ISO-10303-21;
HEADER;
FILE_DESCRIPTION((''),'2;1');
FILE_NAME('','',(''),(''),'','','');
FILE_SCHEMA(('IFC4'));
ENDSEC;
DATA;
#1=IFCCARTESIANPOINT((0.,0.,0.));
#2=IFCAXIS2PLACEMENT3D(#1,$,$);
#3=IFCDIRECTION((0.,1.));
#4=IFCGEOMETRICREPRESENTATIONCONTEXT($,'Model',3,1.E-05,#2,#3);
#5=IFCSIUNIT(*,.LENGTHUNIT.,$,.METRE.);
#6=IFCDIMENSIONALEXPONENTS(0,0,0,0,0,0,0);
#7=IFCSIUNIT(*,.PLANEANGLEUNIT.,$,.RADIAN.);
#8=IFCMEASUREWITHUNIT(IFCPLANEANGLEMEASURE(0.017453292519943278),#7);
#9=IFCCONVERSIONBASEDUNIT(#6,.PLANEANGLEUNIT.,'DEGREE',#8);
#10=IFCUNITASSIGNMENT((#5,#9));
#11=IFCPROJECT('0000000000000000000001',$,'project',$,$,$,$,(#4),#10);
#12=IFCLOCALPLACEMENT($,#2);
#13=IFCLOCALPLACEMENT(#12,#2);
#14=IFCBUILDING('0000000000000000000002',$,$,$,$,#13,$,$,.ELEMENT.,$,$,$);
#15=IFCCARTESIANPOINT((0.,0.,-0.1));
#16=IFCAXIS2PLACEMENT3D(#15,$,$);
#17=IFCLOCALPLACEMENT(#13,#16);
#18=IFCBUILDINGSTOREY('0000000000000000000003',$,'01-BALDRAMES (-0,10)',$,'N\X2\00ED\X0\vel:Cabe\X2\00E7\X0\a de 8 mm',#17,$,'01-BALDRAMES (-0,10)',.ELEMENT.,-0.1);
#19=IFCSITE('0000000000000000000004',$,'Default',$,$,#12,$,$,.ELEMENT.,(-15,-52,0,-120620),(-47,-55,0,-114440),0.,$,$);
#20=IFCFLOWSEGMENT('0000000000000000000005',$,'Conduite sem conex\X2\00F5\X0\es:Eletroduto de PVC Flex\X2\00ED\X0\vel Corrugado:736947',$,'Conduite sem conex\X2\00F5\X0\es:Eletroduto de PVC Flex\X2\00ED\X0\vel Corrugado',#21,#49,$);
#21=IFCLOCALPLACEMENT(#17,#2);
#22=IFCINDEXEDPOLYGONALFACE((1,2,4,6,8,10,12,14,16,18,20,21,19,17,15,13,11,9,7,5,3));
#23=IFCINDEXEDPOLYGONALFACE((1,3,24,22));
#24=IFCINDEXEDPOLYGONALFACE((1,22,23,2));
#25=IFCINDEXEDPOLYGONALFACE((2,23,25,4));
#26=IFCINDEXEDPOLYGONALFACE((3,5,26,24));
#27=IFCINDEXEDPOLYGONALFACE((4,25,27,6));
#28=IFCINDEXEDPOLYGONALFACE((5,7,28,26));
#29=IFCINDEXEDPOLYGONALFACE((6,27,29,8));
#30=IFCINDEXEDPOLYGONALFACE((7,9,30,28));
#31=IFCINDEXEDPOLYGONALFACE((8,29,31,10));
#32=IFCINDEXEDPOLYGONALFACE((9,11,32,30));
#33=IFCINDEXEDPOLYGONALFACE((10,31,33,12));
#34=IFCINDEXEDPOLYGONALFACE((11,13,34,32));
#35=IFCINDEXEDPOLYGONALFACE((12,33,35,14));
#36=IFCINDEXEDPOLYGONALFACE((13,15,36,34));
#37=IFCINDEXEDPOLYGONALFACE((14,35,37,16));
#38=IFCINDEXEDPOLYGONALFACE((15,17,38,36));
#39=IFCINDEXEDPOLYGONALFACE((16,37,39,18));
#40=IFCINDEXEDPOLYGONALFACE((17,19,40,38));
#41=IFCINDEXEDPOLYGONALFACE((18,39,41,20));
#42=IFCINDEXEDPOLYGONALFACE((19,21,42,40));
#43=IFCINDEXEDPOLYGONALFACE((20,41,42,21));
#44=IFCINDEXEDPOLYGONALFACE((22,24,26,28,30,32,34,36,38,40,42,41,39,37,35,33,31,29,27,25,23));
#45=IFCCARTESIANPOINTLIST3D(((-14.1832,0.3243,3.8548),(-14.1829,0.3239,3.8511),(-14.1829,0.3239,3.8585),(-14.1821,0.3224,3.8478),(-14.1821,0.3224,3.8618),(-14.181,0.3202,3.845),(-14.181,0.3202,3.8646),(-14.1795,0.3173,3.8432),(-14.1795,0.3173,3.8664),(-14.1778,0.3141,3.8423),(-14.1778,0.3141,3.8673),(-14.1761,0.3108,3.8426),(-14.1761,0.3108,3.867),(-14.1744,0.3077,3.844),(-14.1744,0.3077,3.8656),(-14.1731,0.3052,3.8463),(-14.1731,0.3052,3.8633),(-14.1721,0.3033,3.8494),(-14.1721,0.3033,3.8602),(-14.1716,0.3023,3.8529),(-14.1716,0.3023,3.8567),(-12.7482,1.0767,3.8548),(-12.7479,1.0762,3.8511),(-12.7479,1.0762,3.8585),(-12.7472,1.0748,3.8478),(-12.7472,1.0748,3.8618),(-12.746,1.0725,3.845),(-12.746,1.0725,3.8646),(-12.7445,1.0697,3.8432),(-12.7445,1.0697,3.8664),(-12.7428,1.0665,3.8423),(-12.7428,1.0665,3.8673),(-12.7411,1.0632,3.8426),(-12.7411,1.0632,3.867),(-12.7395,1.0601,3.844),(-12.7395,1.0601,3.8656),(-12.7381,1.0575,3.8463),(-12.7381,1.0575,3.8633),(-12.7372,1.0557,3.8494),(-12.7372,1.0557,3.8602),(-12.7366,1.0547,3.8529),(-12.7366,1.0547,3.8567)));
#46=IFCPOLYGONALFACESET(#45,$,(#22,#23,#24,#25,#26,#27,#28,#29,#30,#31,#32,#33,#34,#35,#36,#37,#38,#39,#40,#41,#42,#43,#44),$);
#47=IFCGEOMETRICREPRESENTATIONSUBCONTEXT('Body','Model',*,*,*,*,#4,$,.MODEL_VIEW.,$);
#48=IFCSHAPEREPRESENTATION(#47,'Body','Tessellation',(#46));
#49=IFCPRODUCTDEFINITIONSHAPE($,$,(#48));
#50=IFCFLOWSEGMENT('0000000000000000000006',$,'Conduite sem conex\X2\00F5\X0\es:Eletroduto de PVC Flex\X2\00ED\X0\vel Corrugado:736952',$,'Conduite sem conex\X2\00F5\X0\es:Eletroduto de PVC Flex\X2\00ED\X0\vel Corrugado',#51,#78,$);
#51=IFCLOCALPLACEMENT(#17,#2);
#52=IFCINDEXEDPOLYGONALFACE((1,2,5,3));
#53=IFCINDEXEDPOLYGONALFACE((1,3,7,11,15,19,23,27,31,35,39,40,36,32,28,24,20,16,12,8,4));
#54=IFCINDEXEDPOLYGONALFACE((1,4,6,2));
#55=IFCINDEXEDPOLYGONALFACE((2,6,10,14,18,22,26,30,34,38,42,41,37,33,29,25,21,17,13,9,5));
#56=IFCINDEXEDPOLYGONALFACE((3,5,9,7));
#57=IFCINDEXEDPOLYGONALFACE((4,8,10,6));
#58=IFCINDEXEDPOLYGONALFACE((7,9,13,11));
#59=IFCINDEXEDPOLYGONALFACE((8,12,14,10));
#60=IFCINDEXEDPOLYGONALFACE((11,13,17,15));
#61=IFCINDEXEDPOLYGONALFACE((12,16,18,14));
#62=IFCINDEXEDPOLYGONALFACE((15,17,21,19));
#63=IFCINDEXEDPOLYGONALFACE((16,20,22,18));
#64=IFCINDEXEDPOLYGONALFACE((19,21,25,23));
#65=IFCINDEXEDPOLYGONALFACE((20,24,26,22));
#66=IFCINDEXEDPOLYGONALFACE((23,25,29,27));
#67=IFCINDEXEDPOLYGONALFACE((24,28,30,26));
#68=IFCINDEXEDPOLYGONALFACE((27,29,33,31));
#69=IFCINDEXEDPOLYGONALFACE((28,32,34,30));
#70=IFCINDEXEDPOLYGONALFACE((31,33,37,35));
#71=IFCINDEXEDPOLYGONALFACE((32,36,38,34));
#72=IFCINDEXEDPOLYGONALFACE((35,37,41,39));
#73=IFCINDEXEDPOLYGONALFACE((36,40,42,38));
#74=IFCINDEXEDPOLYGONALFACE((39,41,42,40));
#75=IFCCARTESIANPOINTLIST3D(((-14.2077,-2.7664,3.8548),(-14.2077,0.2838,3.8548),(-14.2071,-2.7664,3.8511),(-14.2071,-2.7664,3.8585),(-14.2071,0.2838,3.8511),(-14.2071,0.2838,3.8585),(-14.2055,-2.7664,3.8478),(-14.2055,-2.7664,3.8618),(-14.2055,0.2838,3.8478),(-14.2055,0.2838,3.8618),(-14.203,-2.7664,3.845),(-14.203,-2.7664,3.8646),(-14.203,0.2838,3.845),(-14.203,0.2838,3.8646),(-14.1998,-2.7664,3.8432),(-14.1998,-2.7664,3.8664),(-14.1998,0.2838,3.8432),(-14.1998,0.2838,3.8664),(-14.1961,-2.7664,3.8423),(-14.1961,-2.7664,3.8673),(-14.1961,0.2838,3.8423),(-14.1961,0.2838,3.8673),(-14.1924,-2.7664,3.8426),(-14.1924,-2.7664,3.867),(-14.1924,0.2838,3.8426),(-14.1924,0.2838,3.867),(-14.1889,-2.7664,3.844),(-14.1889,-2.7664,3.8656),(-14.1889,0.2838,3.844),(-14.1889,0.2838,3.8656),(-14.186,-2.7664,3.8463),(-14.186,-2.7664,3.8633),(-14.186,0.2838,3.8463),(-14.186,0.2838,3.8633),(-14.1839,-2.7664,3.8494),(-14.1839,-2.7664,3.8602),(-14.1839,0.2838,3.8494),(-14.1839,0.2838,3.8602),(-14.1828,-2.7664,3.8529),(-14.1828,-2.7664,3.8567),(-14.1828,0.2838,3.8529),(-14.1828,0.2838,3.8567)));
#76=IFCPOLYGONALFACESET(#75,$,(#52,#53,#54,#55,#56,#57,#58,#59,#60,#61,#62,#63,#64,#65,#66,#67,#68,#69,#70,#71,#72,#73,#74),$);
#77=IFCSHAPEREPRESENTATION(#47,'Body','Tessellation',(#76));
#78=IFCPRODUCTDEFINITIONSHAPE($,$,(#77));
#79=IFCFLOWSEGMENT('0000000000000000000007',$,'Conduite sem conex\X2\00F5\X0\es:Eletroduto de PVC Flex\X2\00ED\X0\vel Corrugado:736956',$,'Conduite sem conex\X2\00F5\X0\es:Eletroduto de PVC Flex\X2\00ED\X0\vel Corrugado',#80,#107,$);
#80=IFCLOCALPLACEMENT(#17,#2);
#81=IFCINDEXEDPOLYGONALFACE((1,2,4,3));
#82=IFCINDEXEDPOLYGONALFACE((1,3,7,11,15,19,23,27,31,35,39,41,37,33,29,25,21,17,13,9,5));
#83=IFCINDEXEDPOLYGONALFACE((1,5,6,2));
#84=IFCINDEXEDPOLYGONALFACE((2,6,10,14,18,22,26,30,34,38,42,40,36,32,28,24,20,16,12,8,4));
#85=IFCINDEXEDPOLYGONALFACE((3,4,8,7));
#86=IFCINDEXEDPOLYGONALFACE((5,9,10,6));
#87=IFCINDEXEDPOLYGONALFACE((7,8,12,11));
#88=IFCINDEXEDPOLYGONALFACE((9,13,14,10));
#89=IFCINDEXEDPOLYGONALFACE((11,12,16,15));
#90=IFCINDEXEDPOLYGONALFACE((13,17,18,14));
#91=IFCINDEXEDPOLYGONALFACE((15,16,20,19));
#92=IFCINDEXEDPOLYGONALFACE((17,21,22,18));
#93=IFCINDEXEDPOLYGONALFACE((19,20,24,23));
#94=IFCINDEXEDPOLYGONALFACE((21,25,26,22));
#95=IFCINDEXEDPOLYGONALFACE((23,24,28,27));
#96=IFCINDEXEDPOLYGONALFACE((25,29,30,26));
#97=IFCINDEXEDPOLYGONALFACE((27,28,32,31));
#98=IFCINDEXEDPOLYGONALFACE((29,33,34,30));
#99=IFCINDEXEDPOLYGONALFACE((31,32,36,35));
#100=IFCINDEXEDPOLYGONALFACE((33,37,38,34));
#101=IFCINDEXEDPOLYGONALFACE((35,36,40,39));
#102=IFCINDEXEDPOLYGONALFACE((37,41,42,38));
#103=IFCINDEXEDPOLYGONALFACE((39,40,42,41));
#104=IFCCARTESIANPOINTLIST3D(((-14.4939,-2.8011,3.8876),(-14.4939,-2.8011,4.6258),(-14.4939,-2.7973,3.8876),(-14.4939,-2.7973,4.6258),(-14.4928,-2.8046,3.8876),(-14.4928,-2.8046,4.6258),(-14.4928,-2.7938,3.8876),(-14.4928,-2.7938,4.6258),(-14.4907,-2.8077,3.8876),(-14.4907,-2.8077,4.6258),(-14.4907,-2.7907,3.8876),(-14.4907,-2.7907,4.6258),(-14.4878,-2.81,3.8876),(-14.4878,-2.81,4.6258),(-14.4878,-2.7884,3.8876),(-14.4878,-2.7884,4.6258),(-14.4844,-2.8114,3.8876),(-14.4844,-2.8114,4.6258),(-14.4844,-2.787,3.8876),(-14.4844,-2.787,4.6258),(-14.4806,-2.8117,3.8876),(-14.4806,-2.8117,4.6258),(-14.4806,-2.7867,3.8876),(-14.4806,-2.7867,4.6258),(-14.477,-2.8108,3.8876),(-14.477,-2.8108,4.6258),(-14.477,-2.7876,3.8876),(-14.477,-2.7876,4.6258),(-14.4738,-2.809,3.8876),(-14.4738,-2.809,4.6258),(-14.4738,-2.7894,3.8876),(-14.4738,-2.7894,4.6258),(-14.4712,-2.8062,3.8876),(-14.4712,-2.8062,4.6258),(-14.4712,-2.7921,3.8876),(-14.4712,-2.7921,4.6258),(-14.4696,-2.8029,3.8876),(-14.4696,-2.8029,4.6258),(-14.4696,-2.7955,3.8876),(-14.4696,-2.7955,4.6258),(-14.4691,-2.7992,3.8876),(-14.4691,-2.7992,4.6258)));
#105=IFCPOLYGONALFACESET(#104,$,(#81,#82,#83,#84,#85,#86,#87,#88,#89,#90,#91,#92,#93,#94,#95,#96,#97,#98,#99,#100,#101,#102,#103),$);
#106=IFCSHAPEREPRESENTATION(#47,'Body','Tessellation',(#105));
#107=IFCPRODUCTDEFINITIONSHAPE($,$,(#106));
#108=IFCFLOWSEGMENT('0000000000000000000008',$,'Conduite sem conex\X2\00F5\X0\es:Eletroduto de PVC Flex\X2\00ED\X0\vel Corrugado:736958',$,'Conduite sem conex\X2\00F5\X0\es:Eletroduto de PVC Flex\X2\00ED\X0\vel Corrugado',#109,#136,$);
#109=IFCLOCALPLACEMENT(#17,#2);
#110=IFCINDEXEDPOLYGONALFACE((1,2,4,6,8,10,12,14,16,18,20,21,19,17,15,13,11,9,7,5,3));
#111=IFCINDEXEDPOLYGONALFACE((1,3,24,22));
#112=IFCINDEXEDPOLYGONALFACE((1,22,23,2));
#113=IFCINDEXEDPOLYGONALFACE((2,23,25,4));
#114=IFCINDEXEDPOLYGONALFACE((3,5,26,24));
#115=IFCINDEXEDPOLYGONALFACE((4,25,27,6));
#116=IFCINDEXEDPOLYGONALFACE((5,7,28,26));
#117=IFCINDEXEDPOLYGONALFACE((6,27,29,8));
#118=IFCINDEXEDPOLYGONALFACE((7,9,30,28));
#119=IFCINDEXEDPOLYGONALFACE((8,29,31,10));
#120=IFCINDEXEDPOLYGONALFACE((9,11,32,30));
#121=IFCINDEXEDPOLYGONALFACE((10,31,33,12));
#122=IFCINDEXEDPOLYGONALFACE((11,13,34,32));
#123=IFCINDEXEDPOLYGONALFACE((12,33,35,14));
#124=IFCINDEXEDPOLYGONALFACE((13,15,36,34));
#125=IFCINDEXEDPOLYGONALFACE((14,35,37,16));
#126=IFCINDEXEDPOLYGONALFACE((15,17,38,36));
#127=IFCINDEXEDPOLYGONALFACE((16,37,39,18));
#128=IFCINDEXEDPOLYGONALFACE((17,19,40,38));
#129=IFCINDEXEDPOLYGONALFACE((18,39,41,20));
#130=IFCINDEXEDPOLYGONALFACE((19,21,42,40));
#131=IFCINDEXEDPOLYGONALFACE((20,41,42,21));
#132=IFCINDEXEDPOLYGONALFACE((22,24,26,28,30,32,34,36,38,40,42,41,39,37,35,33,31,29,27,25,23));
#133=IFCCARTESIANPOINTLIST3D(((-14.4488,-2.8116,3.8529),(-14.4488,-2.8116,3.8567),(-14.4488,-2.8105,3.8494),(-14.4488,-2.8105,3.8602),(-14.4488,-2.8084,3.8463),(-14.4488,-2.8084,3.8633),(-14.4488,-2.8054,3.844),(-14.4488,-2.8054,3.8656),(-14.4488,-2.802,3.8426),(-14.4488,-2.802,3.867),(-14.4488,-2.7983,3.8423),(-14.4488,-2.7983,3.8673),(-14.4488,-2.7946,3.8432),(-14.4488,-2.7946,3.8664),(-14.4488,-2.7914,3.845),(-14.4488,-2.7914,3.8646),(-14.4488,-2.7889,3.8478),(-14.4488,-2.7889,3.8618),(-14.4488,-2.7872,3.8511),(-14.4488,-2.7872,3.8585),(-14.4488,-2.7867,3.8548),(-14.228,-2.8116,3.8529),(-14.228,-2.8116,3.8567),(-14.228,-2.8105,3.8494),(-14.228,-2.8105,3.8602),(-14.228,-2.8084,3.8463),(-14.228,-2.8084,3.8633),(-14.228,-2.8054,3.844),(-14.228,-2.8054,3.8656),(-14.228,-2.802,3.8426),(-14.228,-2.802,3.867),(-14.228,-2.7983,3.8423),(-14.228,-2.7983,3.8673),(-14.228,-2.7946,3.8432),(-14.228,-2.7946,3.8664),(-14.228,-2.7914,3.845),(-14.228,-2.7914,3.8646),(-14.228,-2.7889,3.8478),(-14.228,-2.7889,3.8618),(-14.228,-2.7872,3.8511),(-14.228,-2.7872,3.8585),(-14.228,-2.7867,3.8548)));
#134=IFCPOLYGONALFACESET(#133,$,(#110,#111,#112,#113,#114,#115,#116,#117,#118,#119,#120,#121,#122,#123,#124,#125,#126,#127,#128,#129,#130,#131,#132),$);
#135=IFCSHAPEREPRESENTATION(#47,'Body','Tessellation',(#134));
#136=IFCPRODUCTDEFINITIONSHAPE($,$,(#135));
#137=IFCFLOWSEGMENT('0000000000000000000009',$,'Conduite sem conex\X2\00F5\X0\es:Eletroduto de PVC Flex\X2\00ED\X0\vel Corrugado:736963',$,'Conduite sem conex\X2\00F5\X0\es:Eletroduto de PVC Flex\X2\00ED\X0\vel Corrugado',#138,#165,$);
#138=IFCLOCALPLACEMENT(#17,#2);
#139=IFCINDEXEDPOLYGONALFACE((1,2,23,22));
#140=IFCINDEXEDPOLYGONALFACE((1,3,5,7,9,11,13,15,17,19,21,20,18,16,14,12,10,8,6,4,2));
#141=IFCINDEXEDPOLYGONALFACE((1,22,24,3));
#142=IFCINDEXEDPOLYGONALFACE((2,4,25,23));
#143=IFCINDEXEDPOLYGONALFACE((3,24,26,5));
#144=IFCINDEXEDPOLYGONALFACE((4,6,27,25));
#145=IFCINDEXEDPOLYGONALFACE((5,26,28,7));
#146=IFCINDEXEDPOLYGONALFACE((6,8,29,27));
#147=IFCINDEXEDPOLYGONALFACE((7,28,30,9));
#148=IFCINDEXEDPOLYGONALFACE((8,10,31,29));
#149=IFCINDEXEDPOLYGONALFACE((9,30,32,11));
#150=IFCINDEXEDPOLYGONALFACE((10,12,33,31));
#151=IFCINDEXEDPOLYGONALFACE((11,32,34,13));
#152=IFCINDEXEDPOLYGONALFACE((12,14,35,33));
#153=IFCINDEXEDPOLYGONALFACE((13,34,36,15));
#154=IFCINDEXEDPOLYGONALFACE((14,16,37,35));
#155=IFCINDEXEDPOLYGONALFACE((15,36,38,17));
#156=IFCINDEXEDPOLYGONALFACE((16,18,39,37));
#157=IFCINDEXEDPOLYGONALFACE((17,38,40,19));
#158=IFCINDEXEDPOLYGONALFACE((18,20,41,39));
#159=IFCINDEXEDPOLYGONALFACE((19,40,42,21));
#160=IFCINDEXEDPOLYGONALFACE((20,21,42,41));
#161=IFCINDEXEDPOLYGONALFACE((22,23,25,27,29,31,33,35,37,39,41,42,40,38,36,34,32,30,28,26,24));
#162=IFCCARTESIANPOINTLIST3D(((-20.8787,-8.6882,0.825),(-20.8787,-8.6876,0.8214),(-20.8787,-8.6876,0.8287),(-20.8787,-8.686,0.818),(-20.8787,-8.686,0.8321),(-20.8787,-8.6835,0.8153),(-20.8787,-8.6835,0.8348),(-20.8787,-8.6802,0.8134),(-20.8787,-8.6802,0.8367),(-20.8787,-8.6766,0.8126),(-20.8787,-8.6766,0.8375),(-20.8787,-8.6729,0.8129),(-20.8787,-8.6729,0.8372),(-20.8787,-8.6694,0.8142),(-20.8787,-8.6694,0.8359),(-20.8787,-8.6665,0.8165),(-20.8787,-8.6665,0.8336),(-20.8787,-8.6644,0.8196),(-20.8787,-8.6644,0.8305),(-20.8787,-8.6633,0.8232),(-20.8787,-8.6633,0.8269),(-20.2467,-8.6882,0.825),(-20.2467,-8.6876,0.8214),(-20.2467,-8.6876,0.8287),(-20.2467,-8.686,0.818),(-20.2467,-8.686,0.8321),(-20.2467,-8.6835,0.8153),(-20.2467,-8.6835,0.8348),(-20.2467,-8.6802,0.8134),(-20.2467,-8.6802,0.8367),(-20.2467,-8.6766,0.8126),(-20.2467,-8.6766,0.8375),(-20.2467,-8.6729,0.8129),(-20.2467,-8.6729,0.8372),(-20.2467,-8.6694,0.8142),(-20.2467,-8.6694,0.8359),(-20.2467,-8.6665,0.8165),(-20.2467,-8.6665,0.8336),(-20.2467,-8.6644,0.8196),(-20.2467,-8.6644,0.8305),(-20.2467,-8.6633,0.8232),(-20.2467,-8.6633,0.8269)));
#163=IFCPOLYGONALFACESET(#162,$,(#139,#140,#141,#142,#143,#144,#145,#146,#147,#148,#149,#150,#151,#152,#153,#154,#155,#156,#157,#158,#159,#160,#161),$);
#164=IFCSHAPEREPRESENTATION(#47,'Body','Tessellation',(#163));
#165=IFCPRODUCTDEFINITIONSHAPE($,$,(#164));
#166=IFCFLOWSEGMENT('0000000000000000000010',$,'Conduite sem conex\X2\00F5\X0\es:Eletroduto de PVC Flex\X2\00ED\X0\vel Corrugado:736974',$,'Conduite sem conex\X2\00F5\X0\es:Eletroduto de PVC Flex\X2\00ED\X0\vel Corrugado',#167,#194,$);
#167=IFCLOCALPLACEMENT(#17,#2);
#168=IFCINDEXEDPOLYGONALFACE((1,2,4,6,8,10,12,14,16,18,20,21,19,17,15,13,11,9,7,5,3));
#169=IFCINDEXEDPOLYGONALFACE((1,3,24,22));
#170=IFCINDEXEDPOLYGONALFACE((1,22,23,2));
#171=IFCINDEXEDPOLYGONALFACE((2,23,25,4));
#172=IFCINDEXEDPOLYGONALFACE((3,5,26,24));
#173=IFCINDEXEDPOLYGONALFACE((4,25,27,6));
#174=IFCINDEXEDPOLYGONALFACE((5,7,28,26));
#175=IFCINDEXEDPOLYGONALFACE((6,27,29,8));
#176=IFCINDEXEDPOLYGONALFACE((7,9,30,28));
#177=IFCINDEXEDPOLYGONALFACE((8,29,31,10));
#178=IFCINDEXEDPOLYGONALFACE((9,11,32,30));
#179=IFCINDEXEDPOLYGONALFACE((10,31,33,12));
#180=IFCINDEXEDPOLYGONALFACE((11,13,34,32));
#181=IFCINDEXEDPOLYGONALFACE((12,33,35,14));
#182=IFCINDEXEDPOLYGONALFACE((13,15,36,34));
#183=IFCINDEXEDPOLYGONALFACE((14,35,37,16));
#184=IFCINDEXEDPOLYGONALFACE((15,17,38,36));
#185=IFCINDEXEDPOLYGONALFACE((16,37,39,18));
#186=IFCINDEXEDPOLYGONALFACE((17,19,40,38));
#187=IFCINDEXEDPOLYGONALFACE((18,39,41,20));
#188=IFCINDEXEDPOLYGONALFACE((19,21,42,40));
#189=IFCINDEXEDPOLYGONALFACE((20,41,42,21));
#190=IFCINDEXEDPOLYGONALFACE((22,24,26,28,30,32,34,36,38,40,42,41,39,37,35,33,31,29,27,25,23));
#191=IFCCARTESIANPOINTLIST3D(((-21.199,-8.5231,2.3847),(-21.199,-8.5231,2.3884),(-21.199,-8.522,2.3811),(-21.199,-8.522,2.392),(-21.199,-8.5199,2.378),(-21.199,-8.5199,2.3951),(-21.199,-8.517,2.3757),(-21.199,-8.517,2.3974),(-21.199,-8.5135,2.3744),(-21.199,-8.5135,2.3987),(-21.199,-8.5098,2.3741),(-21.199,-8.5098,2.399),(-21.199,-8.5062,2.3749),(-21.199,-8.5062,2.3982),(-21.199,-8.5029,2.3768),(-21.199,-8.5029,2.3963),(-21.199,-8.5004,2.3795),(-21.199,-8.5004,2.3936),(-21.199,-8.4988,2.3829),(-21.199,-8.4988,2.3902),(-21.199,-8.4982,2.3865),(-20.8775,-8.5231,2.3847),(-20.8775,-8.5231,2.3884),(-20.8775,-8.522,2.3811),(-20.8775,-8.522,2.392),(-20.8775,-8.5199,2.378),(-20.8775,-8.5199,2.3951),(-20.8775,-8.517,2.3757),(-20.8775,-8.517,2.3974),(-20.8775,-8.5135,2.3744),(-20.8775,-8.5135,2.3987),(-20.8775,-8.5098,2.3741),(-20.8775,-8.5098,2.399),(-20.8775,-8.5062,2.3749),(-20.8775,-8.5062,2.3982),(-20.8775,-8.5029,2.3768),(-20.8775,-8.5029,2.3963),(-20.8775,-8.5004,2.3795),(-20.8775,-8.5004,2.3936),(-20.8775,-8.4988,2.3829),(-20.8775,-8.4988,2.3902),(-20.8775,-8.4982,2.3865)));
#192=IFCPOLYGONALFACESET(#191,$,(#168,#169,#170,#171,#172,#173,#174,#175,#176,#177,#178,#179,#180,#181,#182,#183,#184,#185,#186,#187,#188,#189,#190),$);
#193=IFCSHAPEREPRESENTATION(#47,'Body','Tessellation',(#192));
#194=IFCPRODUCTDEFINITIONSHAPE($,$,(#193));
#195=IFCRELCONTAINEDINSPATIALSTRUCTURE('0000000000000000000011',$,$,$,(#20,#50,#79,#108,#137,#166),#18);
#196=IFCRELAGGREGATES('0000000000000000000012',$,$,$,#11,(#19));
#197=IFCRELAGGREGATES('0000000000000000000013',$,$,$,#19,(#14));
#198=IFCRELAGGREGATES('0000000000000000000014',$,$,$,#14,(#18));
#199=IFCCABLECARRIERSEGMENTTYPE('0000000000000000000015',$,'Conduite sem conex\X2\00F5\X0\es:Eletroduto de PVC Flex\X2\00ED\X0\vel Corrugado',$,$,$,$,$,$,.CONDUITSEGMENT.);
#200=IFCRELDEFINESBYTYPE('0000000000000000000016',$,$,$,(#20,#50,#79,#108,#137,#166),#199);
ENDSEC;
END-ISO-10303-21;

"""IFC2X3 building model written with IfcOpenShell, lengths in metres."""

from ifc_helpers import new_model, entity, si_unit, converted_unit, direction, frame, frame_2d, origin, place, context, subcontext, project, spatial, circle, extrude, type_object, element, save


model = new_model("IFC2X3")

# Units and contexts
model_context = context("Model", 3, precision=1e-05, world=origin(), true_north=direction((0.0, 1.0)))
body_context = subcontext(model_context, "Body", "Model", "MODEL_VIEW")
ifc_project = project(units=[si_unit("LENGTHUNIT", "METRE"), converted_unit("PLANEANGLEUNIT", "DEGREE", entity("IfcPlaneAngleMeasure", 0.017453292519943278), si_unit("PLANEANGLEUNIT", "RADIAN"), dimensions=[0, 0, 0, 0, 0, 0, 0])], contexts=[model_context])

# Site, building, storey
site_placement = place(None, origin())
site = spatial("IfcSite", under=ifc_project, at=site_placement, Name="Default", CompositionType="ELEMENT", RefLatitude=(-15, -52, 0, -120620), RefLongitude=(-47, -55, 0, -114440), RefElevation=0.0)
building_placement = place(site_placement, origin())
building = spatial("IfcBuilding", under=site, at=building_placement, CompositionType="ELEMENT")
storey_placement = place(building_placement, frame((0.0, 0.0, -0.1)))
storey = spatial("IfcBuildingStorey", under=building, at=storey_placement, Name="01-BALDRAMES (-0,10)", ObjectType="Nível:Cabeça de 8 mm", LongName="01-BALDRAMES (-0,10)", CompositionType="ELEMENT", Elevation=-0.1)

# Flow segments
cable_carrier_segment_type = type_object("IfcCableCarrierSegmentType", Name="Conduite sem conexões:Eletroduto de PVC Flexível Corrugado", PredefinedType="CONDUITSEGMENT")
flow_segment_1_placement = place(storey_placement, origin())
element("IfcFlowSegment", 1, at=flow_segment_1_placement, inside=storey, type_object=cable_carrier_segment_type, Name="Conduite sem conexões:Eletroduto de PVC Flexível Corrugado:736947", ObjectType="Conduite sem conexões:Eletroduto de PVC Flexível Corrugado", context=body_context, shape_type="SweptSolid", body=[
    extrude(circle(Radius=0.0125, at=frame_2d((0.0, 0.0), x_axis=(1.0, 0.0))), frame((-14.1773, 0.3133, 3.8548), z_axis=(0.885651, 0.464351, 0.0), x_axis=(-0.464351, 0.885651, 0.0)), (0.0, 0.0, 1.0), 1.6202),
])
flow_segment_2_placement = place(storey_placement, origin())
element("IfcFlowSegment", 2, at=flow_segment_2_placement, inside=storey, type_object=cable_carrier_segment_type, Name="Conduite sem conexões:Eletroduto de PVC Flexível Corrugado:736952", ObjectType="Conduite sem conexões:Eletroduto de PVC Flexível Corrugado", context=body_context, shape_type="SweptSolid", body=[
    extrude(circle(Radius=0.0125, at=frame_2d((0.0, 0.0), x_axis=(1.0, 0.0))), frame((-14.1952, -2.7664, 3.8548), z_axis=(0.0, 1.0, 0.0), x_axis=(-1.0, 0.0, 0.0)), (0.0, 0.0, 1.0), 3.0502),
])
flow_segment_3_placement = place(storey_placement, origin())
element("IfcFlowSegment", 3, at=flow_segment_3_placement, inside=storey, type_object=cable_carrier_segment_type, Name="Conduite sem conexões:Eletroduto de PVC Flexível Corrugado:736956", ObjectType="Conduite sem conexões:Eletroduto de PVC Flexível Corrugado", context=body_context, shape_type="SweptSolid", body=[
    extrude(circle(Radius=0.0125, at=frame_2d((0.0, 0.0), x_axis=(1.0, 0.0))), frame((-14.4816, -2.7992, 3.8876)), (0.0, 0.0, 1.0), 0.7382),
])
flow_segment_4_placement = place(storey_placement, origin())
element("IfcFlowSegment", 4, at=flow_segment_4_placement, inside=storey, type_object=cable_carrier_segment_type, Name="Conduite sem conexões:Eletroduto de PVC Flexível Corrugado:736958", ObjectType="Conduite sem conexões:Eletroduto de PVC Flexível Corrugado", context=body_context, shape_type="SweptSolid", body=[
    extrude(circle(Radius=0.0125, at=frame_2d((0.0, 0.0), x_axis=(1.0, 0.0))), frame((-14.4488, -2.7992, 3.8548), z_axis=(1.0, 0.0, 0.0), x_axis=(0.0, 1.0, 0.0)), (0.0, 0.0, 1.0), 0.2208),
])
flow_segment_5_placement = place(storey_placement, origin())
element("IfcFlowSegment", 5, at=flow_segment_5_placement, inside=storey, type_object=cable_carrier_segment_type, Name="Conduite sem conexões:Eletroduto de PVC Flexível Corrugado:736963", ObjectType="Conduite sem conexões:Eletroduto de PVC Flexível Corrugado", context=body_context, shape_type="SweptSolid", body=[
    extrude(circle(Radius=0.0125, at=frame_2d((0.0, 0.0), x_axis=(1.0, 0.0))), frame((-20.8787, -8.6757, 0.825), z_axis=(1.0, 0.0, 0.0), x_axis=(0.0, -1.0, 0.0)), (0.0, 0.0, 1.0), 0.632),
])
flow_segment_6_placement = place(storey_placement, origin())
element("IfcFlowSegment", 6, at=flow_segment_6_placement, inside=storey, type_object=cable_carrier_segment_type, Name="Conduite sem conexões:Eletroduto de PVC Flexível Corrugado:736974", ObjectType="Conduite sem conexões:Eletroduto de PVC Flexível Corrugado", context=body_context, shape_type="SweptSolid", body=[
    extrude(circle(Radius=0.0125, at=frame_2d((0.0, 0.0), x_axis=(1.0, 0.0))), frame((-21.199, -8.5107, 2.3865), z_axis=(1.0, -0.000003, 0.0), x_axis=(0.000003, 1.0, 0.0)), (0.0, 0.0, 1.0), 0.3216),
])

save(model, "model.ifc")
